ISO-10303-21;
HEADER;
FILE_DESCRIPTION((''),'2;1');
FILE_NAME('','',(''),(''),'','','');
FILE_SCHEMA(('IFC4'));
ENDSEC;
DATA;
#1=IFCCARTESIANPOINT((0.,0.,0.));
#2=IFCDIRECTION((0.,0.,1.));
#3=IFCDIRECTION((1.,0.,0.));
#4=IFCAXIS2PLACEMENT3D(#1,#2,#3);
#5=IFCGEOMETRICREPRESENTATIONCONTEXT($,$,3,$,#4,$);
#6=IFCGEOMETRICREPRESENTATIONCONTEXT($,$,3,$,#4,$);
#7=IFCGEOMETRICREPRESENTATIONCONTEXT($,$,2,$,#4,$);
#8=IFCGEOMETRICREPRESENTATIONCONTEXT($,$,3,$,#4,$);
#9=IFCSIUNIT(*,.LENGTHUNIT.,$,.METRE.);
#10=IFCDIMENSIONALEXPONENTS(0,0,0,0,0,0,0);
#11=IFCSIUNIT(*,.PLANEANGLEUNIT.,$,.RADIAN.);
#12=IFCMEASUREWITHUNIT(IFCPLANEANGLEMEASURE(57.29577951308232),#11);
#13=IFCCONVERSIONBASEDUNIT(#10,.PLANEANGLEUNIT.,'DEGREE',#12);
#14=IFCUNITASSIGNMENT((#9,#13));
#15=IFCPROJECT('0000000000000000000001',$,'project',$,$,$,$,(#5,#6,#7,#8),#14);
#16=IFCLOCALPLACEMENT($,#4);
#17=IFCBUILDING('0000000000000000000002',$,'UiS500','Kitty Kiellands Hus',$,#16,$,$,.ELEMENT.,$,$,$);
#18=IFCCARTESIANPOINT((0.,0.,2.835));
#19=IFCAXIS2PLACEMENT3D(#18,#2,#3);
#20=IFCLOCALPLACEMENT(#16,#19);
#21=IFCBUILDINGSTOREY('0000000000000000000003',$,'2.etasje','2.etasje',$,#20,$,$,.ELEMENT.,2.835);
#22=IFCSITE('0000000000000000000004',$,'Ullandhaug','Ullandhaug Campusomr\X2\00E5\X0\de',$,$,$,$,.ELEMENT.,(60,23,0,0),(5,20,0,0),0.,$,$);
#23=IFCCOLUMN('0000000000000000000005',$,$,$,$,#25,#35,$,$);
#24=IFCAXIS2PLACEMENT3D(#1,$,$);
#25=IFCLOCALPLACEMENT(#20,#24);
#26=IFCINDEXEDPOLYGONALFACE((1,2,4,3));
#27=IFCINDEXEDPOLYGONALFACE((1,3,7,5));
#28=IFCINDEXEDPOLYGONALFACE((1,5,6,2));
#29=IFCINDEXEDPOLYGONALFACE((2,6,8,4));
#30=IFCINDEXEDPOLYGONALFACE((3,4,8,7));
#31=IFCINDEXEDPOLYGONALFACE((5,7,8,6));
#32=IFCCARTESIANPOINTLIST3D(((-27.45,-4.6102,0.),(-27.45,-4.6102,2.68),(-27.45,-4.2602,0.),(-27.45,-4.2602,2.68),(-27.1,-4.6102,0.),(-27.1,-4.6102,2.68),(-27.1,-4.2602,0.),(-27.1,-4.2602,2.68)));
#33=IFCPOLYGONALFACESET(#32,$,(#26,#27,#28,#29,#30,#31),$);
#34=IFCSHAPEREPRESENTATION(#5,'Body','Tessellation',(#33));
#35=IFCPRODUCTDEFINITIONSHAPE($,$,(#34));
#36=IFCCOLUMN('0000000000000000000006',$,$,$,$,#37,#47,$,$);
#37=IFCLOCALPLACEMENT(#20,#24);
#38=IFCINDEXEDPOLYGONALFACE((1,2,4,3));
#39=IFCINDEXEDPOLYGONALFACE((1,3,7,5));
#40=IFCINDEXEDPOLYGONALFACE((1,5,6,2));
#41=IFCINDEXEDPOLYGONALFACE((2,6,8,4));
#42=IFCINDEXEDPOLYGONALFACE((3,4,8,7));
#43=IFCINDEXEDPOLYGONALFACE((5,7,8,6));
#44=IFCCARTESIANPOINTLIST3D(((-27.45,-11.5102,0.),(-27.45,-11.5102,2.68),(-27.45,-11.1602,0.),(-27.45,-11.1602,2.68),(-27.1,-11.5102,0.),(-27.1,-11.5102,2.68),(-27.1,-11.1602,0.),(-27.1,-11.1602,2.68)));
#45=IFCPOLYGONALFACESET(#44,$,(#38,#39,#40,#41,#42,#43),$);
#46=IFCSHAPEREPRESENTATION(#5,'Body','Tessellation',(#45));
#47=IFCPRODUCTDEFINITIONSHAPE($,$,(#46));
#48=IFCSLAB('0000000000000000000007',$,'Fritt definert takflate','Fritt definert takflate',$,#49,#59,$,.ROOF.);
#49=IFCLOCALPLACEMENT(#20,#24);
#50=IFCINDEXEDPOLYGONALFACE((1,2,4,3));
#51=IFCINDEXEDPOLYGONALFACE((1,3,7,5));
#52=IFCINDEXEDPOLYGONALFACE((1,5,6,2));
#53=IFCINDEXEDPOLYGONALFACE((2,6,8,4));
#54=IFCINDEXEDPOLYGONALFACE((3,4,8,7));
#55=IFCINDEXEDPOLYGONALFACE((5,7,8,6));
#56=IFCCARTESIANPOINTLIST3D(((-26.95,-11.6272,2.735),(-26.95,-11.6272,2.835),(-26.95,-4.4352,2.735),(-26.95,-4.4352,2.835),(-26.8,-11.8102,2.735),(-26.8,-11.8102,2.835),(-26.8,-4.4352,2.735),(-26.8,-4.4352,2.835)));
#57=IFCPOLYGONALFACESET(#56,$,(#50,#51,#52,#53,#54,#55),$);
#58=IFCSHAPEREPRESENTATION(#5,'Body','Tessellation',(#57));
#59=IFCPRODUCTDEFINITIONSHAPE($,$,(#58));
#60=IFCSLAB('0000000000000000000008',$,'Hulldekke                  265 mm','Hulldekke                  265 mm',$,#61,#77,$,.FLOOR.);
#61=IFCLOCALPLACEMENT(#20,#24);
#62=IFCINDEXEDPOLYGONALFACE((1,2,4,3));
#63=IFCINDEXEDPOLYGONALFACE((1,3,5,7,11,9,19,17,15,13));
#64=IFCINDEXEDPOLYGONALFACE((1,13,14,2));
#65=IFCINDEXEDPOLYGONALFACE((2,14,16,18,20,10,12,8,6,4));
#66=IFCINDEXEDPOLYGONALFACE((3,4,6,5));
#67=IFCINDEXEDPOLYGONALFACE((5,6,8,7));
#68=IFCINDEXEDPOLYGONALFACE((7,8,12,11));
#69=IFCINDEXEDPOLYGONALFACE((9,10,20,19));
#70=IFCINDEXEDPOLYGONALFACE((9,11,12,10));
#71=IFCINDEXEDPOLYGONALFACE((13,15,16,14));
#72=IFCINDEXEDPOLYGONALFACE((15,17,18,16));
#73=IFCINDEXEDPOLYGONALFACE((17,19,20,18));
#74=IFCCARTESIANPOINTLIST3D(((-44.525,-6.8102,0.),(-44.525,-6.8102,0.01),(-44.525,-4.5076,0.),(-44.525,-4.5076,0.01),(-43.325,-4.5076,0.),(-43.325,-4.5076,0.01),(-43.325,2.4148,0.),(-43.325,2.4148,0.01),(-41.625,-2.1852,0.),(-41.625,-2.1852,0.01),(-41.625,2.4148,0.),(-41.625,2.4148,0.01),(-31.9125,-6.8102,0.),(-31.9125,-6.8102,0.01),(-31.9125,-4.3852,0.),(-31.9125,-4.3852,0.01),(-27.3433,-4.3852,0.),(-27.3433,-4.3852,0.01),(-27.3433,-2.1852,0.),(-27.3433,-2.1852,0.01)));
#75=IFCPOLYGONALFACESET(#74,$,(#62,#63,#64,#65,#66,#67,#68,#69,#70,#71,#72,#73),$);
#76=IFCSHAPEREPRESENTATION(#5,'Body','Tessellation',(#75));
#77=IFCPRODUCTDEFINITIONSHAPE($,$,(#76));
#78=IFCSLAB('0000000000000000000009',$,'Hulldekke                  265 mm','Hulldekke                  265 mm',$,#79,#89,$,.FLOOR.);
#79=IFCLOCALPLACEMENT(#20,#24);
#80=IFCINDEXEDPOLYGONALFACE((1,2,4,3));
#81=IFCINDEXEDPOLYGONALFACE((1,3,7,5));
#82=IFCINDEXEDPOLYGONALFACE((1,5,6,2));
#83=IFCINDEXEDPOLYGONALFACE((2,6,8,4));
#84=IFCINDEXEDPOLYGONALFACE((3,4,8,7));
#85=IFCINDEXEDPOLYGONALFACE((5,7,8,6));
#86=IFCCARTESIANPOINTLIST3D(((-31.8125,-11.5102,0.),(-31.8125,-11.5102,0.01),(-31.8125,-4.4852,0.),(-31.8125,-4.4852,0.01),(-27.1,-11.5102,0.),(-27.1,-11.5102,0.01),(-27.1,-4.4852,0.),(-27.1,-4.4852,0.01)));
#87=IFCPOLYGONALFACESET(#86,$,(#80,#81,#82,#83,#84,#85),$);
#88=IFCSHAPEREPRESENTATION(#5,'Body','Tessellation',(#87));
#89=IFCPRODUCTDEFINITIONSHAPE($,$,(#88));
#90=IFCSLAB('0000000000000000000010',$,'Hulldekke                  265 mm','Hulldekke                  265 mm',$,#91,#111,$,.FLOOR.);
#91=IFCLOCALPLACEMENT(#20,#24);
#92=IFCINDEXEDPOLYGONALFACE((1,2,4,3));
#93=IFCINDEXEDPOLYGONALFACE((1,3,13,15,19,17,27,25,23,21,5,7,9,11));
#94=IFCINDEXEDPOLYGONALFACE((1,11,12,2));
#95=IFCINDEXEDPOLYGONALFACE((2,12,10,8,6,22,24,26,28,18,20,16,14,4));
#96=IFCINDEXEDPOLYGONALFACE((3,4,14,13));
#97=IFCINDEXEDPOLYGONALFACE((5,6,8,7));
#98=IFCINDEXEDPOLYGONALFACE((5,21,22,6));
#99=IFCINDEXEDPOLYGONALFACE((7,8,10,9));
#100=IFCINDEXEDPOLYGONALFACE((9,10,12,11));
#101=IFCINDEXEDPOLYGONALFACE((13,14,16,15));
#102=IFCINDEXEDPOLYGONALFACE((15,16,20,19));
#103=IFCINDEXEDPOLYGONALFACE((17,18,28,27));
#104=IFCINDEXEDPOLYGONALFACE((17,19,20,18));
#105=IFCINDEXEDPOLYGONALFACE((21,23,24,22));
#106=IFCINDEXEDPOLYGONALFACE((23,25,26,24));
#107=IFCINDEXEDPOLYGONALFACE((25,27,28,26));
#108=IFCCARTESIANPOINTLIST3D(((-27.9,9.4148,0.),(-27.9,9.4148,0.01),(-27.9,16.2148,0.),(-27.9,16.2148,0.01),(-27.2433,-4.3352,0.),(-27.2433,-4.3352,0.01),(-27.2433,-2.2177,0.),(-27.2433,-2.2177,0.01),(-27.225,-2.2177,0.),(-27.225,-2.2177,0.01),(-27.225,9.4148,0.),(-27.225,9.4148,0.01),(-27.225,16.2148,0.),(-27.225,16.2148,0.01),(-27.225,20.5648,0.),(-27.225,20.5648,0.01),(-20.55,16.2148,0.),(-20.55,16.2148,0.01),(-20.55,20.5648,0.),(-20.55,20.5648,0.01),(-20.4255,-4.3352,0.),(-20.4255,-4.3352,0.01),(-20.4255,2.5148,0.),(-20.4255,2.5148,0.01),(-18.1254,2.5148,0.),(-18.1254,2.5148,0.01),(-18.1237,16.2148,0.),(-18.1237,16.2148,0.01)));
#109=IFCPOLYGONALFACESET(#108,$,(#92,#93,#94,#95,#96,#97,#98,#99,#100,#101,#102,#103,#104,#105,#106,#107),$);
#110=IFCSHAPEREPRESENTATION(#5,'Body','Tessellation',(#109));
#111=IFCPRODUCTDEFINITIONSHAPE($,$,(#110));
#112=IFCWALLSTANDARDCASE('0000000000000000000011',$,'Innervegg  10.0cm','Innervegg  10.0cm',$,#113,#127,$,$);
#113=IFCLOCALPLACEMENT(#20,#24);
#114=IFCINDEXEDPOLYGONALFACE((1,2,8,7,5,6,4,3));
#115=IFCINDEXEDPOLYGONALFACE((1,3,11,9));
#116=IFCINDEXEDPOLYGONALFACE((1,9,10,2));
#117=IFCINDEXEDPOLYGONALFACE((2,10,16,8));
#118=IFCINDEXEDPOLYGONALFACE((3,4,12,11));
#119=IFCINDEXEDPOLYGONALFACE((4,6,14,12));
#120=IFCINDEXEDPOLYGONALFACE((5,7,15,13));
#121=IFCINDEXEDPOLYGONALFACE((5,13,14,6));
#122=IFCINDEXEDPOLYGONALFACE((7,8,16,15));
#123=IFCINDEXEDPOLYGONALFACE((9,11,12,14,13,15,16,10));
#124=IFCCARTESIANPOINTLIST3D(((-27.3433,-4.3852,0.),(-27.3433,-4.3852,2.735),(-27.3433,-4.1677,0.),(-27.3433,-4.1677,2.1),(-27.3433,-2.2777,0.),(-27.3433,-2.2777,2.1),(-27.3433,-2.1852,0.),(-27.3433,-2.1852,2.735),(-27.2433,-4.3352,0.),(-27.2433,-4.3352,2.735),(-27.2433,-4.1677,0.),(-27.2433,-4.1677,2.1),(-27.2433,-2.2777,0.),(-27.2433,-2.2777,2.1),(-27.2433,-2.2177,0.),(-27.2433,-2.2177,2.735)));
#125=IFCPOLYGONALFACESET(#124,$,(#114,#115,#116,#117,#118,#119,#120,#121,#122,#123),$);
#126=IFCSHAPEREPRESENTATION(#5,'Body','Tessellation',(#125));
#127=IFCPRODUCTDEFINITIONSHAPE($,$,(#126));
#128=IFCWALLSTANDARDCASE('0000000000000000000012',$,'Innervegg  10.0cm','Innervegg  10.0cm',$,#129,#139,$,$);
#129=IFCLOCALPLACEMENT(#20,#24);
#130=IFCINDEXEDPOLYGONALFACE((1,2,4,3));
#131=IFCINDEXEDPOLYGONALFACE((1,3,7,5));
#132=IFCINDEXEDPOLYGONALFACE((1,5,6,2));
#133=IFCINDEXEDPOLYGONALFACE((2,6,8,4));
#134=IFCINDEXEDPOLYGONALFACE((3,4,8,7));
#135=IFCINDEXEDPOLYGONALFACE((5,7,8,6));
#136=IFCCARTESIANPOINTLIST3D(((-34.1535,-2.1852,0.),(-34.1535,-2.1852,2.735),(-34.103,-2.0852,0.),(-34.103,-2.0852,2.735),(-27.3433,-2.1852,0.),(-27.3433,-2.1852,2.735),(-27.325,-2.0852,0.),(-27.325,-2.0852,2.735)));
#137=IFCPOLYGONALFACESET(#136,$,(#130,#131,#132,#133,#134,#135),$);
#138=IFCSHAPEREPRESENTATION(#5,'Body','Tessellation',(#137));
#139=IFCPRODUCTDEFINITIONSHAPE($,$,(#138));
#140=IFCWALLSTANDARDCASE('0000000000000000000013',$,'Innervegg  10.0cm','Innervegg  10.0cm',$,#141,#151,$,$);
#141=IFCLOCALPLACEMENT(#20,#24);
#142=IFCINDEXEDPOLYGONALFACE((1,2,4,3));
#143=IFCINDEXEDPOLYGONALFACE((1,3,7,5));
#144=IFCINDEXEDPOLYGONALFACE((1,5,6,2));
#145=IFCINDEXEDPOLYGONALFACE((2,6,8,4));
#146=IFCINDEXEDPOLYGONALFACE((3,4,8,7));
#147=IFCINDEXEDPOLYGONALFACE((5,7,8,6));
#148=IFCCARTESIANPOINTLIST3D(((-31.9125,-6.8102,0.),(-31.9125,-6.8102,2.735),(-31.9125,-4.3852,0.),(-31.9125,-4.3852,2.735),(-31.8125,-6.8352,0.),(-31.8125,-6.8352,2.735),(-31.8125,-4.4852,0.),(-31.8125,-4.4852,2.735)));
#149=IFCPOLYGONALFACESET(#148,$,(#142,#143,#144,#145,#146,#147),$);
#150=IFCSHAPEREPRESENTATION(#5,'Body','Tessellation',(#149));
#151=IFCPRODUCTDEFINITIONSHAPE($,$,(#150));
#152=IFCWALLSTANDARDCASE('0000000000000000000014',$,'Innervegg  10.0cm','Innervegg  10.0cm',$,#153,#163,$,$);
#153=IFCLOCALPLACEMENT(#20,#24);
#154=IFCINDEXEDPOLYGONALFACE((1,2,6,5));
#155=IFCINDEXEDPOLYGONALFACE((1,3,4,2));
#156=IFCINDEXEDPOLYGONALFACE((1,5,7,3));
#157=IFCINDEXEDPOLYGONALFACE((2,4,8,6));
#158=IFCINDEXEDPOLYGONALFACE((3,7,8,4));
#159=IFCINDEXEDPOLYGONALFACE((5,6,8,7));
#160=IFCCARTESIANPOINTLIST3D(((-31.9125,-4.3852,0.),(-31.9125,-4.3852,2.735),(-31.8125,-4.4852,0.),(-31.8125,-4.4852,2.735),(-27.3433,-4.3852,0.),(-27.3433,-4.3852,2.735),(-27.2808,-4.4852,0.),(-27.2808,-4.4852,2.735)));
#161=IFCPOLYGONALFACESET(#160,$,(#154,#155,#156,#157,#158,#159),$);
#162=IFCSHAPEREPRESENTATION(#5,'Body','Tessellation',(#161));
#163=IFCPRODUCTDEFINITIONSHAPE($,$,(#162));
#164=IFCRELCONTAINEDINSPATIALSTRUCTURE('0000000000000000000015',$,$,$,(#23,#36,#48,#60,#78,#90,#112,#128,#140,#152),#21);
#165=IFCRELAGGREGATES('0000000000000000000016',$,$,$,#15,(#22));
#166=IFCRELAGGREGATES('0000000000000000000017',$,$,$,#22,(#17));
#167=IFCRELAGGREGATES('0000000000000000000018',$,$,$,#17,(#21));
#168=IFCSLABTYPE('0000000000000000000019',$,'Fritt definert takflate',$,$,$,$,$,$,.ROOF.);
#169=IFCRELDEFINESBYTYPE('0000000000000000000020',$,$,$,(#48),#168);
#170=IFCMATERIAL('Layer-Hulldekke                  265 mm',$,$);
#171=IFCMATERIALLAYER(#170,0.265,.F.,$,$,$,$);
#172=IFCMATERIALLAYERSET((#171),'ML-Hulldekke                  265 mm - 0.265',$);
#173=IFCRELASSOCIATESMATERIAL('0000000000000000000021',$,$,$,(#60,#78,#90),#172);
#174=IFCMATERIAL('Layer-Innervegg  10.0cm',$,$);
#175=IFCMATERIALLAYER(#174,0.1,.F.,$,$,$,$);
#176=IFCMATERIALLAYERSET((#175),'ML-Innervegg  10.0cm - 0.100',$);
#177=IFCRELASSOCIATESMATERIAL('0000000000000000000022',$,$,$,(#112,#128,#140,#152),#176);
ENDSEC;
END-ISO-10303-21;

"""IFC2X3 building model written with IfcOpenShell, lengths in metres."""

from ifc_helpers import new_model, entity, si_unit, converted_unit, frame, origin_with_axes, origin_2d_with_axis, place, context, project, spatial, polyline, rectangle, outline, extrude, material, layer, layer_set, layer_usage, type_object, element, save


model = new_model("IFC2X3")

# Units and contexts
context_of_model_1 = context(None, 3, world=origin_with_axes())
context_of_model_2 = context(None, 3, world=origin_with_axes())
context_of_model_3 = context(None, 2, world=origin_with_axes())
context_of_model_4 = context(None, 3, world=origin_with_axes())
ifc_project = project(units=[si_unit("LENGTHUNIT", "METRE"), converted_unit("PLANEANGLEUNIT", "DEGREE", entity("IfcPlaneAngleMeasure", 57.29577951308232), si_unit("PLANEANGLEUNIT", "RADIAN"), dimensions=[0, 0, 0, 0, 0, 0, 0])], contexts=[context_of_model_1, context_of_model_2, context_of_model_3, context_of_model_4])

# Site, building, storey
site = spatial("IfcSite", under=ifc_project, Name="Ullandhaug", Description="Ullandhaug Campusområde", CompositionType="ELEMENT", RefLatitude=(60, 23, 0, 0), RefLongitude=(5, 20, 0, 0), RefElevation=0.0)
building_placement = place(None, origin_with_axes())
building = spatial("IfcBuilding", under=site, at=building_placement, Name="UiS500", Description="Kitty Kiellands Hus", CompositionType="ELEMENT")
storey_placement = place(building_placement, frame((0.0, 0.0, 2.835), z_axis=(0.0, 0.0, 1.0), x_axis=(1.0, 0.0, 0.0)))
storey = spatial("IfcBuildingStorey", under=building, at=storey_placement, Name="2.etasje", Description="2.etasje", CompositionType="ELEMENT", Elevation=2.835)

# Columns
for number, where, z_axis, x_axis in (
    (1, (-27.275, -4.4352, 0.0), (0.0, 0.0, 1.0), (1.0, 0.0, 0.0)),
    (2, (-27.275, -11.3352, 0.0), (0.0, 0.0, 1.0), (1.0, 0.0, 0.0)),
):
    element("IfcColumn", number, at=place(storey_placement, frame(where, z_axis=z_axis, x_axis=x_axis)), inside=storey, context=context_of_model_1, shape_type="SweptSolid", body=[
        extrude(rectangle(XDim=0.35, YDim=0.35, at=origin_2d_with_axis()), origin_with_axes(), (0.0, 0.0, 1.0), 2.68),
    ])

# Slabs
slab_type = type_object("IfcSlabType", Name="Fritt definert takflate", PredefinedType="ROOF")
slab_1_placement = place(storey_placement, frame((-26.95, -11.6272, 2.735), z_axis=(0.0, 0.0, 1.0), x_axis=(0.633926, -0.773394, 0.0)))
element("IfcSlab", 3, at=slab_1_placement, inside=storey, type_object=slab_type, Name="Fritt definert takflate", Description="Fritt definert takflate", PredefinedType="ROOF", context=context_of_model_1, shape_type="SweptSolid", body=[
    extrude(outline(polyline([(0.0, 0.0), (0.2366, 0.0), (-5.4672, 4.6752), (-5.5622, 4.5592), (0.0, 0.0)])), origin_with_axes(), (0.0, 0.0, 1.0), 0.1),
])
ifc_material_1 = material(Name="Layer-Hulldekke                  265 mm")
ifc_layer_1 = layer(ifc_material_1, 0.265, ventilated=False)
ifc_layer_set_1 = layer_set([ifc_layer_1], Name="ML-Hulldekke                  265 mm - 0.265")
ifc_layer_usage_1 = layer_usage(ifc_layer_set_1, "AXIS2", "POSITIVE", 0.0)
slab_2_placement = place(storey_placement, frame((-27.3433, -4.3852, 0.0), z_axis=(0.0, 0.0, 1.0), x_axis=(1.0, 0.0, 0.0)))
element("IfcSlab", 4, at=slab_2_placement, inside=storey, material=ifc_layer_usage_1, Name="Hulldekke                  265 mm", Description="Hulldekke                  265 mm", PredefinedType="FLOOR", context=context_of_model_1, shape_type="SweptSolid", body=[
    extrude(outline(polyline([(0.0, 0.0), (2.2, 0.0), (2.2, 14.2817), (6.8, 14.2817), (6.8, 15.9817), (-0.1223, 15.9817), (-0.1223, 17.1817), (-2.425, 17.1817), (-2.425, 4.5692), (0.0, 4.5692), (0.0, 0.0)])), frame((0.0, 0.0, 0.0), z_axis=(0.0, 0.0, 1.0), x_axis=(0.0, 1.0, 0.0)), (0.0, 0.0, 1.0), 0.01),
])
slab_3_placement = place(storey_placement, frame((-31.8125, -11.5102, 0.0), z_axis=(0.0, 0.0, 1.0), x_axis=(1.0, 0.0, 0.0)))
element("IfcSlab", 5, at=slab_3_placement, inside=storey, material=ifc_layer_usage_1, Name="Hulldekke                  265 mm", Description="Hulldekke                  265 mm", PredefinedType="FLOOR", context=context_of_model_1, shape_type="SweptSolid", body=[
    extrude(outline(polyline([(0.0, 0.0), (4.7125, 0.0), (4.7125, 7.025), (0.0, 7.025), (0.0, 0.0)])), origin_with_axes(), (0.0, 0.0, 1.0), 0.01),
])
slab_4_placement = place(storey_placement, frame((-27.2433, -4.3352, 0.0), z_axis=(0.0, 0.0, 1.0), x_axis=(1.0, 0.0, 0.0)))
element("IfcSlab", 6, at=slab_4_placement, inside=storey, material=ifc_layer_usage_1, Name="Hulldekke                  265 mm", Description="Hulldekke                  265 mm", PredefinedType="FLOOR", context=context_of_model_1, shape_type="SweptSolid", body=[
    extrude(outline(polyline([(0.0, 0.0), (6.8178, 0.0), (6.8178, 6.85), (9.1179, 6.85), (9.1196, 20.55), (6.6933, 20.55), (6.6933, 24.9), (0.0183, 24.9), (0.0183, 20.55), (-0.6567, 20.55), (-0.6567, 13.75), (0.0183, 13.75), (0.0183, 2.1175), (0.0, 2.1175), (0.0, 0.0)])), origin_with_axes(), (0.0, 0.0, 1.0), 0.01),
])

# Wall, opening
ifc_material_2 = material(Name="Layer-Innervegg  10.0cm")
ifc_layer_2 = layer(ifc_material_2, 0.1, ventilated=False)
ifc_layer_set_2 = layer_set([ifc_layer_2], Name="ML-Innervegg  10.0cm - 0.100")
ifc_layer_usage_2 = layer_usage(ifc_layer_set_2, "AXIS2", "POSITIVE", 0.0)
wall_1_placement = place(storey_placement, frame((-27.2433, -4.3352, 0.0), z_axis=(0.0, 0.0, 1.0), x_axis=(0.0, 1.0, 0.0)))
wall_1 = element("IfcWallStandardCase", 7, at=wall_1_placement, inside=storey, material=ifc_layer_usage_2, Name="Innervegg  10.0cm", Description="Innervegg  10.0cm", context=context_of_model_1, shape_type="SweptSolid", body=[
    extrude(outline(polyline([(0.0, 0.0), (2.1175, 0.0), (2.15, 0.1), (-0.05, 0.1), (0.0, 0.0)])), frame((0.0, 0.0, 0.0), z_axis=(0.0, 0.0, 1.0), x_axis=(1.0, 0.0, 0.0)), (0.0, 0.0, 1.0), 2.735),
])
opening_1_placement = place(wall_1_placement, frame((0.1675, 0.1, 0.0), z_axis=(0.0, 0.0, 1.0), x_axis=(1.0, 0.0, 0.0)))
element("IfcOpeningElement", 8, at=opening_1_placement, cuts=wall_1, context=context_of_model_1, shape_type="SweptSolid", body=[
    extrude(outline(polyline([(0.0, 0.0), (2.1, 0.0), (2.1, 1.89), (0.0, 1.89), (0.0, 0.0)])), frame((0.0, 0.0, 0.0), z_axis=(0.0, 1.0, 0.0), x_axis=(0.0, 0.0, 1.0)), (0.0, 0.0, -1.0), 0.1),
])

# Walls
wall_2_placement = place(storey_placement, frame((-27.325, -2.0852, 0.0), z_axis=(0.0, 0.0, 1.0), x_axis=(-1.0, 0.0, 0.0)))
element("IfcWallStandardCase", 9, at=wall_2_placement, inside=storey, material=ifc_layer_usage_2, Name="Innervegg  10.0cm", Description="Innervegg  10.0cm", context=context_of_model_1, shape_type="SweptSolid", body=[
    extrude(outline(polyline([(0.0, 0.0), (6.778, 0.0), (6.8285, 0.1), (0.0183, 0.1), (0.0, 0.0)])), frame((0.0, 0.0, 0.0), z_axis=(0.0, 0.0, 1.0), x_axis=(1.0, 0.0, 0.0)), (0.0, 0.0, 1.0), 2.735),
])
wall_3_placement = place(storey_placement, frame((-31.8125, -6.8352, 0.0), z_axis=(0.0, 0.0, 1.0), x_axis=(0.0, 1.0, 0.0)))
element("IfcWallStandardCase", 10, at=wall_3_placement, inside=storey, material=ifc_layer_usage_2, Name="Innervegg  10.0cm", Description="Innervegg  10.0cm", context=context_of_model_1, shape_type="SweptSolid", body=[
    extrude(outline(polyline([(0.0, 0.0), (2.35, 0.0), (2.45, 0.1), (0.025, 0.1), (0.0, 0.0)])), frame((0.0, 0.0, 0.0), z_axis=(0.0, 0.0, 1.0), x_axis=(1.0, 0.0, 0.0)), (0.0, 0.0, 1.0), 2.735),
])
wall_4_placement = place(storey_placement, frame((-31.8125, -4.4852, 0.0), z_axis=(0.0, 0.0, 1.0), x_axis=(1.0, 0.0, 0.0)))
element("IfcWallStandardCase", 11, at=wall_4_placement, inside=storey, material=ifc_layer_usage_2, Name="Innervegg  10.0cm", Description="Innervegg  10.0cm", context=context_of_model_1, shape_type="SweptSolid", body=[
    extrude(outline(polyline([(0.0, 0.0), (4.5317, 0.0), (4.4692, 0.1), (-0.1, 0.1), (0.0, 0.0)])), origin_with_axes(), (0.0, 0.0, 1.0), 2.735),
])

save(model, "model.ifc")
